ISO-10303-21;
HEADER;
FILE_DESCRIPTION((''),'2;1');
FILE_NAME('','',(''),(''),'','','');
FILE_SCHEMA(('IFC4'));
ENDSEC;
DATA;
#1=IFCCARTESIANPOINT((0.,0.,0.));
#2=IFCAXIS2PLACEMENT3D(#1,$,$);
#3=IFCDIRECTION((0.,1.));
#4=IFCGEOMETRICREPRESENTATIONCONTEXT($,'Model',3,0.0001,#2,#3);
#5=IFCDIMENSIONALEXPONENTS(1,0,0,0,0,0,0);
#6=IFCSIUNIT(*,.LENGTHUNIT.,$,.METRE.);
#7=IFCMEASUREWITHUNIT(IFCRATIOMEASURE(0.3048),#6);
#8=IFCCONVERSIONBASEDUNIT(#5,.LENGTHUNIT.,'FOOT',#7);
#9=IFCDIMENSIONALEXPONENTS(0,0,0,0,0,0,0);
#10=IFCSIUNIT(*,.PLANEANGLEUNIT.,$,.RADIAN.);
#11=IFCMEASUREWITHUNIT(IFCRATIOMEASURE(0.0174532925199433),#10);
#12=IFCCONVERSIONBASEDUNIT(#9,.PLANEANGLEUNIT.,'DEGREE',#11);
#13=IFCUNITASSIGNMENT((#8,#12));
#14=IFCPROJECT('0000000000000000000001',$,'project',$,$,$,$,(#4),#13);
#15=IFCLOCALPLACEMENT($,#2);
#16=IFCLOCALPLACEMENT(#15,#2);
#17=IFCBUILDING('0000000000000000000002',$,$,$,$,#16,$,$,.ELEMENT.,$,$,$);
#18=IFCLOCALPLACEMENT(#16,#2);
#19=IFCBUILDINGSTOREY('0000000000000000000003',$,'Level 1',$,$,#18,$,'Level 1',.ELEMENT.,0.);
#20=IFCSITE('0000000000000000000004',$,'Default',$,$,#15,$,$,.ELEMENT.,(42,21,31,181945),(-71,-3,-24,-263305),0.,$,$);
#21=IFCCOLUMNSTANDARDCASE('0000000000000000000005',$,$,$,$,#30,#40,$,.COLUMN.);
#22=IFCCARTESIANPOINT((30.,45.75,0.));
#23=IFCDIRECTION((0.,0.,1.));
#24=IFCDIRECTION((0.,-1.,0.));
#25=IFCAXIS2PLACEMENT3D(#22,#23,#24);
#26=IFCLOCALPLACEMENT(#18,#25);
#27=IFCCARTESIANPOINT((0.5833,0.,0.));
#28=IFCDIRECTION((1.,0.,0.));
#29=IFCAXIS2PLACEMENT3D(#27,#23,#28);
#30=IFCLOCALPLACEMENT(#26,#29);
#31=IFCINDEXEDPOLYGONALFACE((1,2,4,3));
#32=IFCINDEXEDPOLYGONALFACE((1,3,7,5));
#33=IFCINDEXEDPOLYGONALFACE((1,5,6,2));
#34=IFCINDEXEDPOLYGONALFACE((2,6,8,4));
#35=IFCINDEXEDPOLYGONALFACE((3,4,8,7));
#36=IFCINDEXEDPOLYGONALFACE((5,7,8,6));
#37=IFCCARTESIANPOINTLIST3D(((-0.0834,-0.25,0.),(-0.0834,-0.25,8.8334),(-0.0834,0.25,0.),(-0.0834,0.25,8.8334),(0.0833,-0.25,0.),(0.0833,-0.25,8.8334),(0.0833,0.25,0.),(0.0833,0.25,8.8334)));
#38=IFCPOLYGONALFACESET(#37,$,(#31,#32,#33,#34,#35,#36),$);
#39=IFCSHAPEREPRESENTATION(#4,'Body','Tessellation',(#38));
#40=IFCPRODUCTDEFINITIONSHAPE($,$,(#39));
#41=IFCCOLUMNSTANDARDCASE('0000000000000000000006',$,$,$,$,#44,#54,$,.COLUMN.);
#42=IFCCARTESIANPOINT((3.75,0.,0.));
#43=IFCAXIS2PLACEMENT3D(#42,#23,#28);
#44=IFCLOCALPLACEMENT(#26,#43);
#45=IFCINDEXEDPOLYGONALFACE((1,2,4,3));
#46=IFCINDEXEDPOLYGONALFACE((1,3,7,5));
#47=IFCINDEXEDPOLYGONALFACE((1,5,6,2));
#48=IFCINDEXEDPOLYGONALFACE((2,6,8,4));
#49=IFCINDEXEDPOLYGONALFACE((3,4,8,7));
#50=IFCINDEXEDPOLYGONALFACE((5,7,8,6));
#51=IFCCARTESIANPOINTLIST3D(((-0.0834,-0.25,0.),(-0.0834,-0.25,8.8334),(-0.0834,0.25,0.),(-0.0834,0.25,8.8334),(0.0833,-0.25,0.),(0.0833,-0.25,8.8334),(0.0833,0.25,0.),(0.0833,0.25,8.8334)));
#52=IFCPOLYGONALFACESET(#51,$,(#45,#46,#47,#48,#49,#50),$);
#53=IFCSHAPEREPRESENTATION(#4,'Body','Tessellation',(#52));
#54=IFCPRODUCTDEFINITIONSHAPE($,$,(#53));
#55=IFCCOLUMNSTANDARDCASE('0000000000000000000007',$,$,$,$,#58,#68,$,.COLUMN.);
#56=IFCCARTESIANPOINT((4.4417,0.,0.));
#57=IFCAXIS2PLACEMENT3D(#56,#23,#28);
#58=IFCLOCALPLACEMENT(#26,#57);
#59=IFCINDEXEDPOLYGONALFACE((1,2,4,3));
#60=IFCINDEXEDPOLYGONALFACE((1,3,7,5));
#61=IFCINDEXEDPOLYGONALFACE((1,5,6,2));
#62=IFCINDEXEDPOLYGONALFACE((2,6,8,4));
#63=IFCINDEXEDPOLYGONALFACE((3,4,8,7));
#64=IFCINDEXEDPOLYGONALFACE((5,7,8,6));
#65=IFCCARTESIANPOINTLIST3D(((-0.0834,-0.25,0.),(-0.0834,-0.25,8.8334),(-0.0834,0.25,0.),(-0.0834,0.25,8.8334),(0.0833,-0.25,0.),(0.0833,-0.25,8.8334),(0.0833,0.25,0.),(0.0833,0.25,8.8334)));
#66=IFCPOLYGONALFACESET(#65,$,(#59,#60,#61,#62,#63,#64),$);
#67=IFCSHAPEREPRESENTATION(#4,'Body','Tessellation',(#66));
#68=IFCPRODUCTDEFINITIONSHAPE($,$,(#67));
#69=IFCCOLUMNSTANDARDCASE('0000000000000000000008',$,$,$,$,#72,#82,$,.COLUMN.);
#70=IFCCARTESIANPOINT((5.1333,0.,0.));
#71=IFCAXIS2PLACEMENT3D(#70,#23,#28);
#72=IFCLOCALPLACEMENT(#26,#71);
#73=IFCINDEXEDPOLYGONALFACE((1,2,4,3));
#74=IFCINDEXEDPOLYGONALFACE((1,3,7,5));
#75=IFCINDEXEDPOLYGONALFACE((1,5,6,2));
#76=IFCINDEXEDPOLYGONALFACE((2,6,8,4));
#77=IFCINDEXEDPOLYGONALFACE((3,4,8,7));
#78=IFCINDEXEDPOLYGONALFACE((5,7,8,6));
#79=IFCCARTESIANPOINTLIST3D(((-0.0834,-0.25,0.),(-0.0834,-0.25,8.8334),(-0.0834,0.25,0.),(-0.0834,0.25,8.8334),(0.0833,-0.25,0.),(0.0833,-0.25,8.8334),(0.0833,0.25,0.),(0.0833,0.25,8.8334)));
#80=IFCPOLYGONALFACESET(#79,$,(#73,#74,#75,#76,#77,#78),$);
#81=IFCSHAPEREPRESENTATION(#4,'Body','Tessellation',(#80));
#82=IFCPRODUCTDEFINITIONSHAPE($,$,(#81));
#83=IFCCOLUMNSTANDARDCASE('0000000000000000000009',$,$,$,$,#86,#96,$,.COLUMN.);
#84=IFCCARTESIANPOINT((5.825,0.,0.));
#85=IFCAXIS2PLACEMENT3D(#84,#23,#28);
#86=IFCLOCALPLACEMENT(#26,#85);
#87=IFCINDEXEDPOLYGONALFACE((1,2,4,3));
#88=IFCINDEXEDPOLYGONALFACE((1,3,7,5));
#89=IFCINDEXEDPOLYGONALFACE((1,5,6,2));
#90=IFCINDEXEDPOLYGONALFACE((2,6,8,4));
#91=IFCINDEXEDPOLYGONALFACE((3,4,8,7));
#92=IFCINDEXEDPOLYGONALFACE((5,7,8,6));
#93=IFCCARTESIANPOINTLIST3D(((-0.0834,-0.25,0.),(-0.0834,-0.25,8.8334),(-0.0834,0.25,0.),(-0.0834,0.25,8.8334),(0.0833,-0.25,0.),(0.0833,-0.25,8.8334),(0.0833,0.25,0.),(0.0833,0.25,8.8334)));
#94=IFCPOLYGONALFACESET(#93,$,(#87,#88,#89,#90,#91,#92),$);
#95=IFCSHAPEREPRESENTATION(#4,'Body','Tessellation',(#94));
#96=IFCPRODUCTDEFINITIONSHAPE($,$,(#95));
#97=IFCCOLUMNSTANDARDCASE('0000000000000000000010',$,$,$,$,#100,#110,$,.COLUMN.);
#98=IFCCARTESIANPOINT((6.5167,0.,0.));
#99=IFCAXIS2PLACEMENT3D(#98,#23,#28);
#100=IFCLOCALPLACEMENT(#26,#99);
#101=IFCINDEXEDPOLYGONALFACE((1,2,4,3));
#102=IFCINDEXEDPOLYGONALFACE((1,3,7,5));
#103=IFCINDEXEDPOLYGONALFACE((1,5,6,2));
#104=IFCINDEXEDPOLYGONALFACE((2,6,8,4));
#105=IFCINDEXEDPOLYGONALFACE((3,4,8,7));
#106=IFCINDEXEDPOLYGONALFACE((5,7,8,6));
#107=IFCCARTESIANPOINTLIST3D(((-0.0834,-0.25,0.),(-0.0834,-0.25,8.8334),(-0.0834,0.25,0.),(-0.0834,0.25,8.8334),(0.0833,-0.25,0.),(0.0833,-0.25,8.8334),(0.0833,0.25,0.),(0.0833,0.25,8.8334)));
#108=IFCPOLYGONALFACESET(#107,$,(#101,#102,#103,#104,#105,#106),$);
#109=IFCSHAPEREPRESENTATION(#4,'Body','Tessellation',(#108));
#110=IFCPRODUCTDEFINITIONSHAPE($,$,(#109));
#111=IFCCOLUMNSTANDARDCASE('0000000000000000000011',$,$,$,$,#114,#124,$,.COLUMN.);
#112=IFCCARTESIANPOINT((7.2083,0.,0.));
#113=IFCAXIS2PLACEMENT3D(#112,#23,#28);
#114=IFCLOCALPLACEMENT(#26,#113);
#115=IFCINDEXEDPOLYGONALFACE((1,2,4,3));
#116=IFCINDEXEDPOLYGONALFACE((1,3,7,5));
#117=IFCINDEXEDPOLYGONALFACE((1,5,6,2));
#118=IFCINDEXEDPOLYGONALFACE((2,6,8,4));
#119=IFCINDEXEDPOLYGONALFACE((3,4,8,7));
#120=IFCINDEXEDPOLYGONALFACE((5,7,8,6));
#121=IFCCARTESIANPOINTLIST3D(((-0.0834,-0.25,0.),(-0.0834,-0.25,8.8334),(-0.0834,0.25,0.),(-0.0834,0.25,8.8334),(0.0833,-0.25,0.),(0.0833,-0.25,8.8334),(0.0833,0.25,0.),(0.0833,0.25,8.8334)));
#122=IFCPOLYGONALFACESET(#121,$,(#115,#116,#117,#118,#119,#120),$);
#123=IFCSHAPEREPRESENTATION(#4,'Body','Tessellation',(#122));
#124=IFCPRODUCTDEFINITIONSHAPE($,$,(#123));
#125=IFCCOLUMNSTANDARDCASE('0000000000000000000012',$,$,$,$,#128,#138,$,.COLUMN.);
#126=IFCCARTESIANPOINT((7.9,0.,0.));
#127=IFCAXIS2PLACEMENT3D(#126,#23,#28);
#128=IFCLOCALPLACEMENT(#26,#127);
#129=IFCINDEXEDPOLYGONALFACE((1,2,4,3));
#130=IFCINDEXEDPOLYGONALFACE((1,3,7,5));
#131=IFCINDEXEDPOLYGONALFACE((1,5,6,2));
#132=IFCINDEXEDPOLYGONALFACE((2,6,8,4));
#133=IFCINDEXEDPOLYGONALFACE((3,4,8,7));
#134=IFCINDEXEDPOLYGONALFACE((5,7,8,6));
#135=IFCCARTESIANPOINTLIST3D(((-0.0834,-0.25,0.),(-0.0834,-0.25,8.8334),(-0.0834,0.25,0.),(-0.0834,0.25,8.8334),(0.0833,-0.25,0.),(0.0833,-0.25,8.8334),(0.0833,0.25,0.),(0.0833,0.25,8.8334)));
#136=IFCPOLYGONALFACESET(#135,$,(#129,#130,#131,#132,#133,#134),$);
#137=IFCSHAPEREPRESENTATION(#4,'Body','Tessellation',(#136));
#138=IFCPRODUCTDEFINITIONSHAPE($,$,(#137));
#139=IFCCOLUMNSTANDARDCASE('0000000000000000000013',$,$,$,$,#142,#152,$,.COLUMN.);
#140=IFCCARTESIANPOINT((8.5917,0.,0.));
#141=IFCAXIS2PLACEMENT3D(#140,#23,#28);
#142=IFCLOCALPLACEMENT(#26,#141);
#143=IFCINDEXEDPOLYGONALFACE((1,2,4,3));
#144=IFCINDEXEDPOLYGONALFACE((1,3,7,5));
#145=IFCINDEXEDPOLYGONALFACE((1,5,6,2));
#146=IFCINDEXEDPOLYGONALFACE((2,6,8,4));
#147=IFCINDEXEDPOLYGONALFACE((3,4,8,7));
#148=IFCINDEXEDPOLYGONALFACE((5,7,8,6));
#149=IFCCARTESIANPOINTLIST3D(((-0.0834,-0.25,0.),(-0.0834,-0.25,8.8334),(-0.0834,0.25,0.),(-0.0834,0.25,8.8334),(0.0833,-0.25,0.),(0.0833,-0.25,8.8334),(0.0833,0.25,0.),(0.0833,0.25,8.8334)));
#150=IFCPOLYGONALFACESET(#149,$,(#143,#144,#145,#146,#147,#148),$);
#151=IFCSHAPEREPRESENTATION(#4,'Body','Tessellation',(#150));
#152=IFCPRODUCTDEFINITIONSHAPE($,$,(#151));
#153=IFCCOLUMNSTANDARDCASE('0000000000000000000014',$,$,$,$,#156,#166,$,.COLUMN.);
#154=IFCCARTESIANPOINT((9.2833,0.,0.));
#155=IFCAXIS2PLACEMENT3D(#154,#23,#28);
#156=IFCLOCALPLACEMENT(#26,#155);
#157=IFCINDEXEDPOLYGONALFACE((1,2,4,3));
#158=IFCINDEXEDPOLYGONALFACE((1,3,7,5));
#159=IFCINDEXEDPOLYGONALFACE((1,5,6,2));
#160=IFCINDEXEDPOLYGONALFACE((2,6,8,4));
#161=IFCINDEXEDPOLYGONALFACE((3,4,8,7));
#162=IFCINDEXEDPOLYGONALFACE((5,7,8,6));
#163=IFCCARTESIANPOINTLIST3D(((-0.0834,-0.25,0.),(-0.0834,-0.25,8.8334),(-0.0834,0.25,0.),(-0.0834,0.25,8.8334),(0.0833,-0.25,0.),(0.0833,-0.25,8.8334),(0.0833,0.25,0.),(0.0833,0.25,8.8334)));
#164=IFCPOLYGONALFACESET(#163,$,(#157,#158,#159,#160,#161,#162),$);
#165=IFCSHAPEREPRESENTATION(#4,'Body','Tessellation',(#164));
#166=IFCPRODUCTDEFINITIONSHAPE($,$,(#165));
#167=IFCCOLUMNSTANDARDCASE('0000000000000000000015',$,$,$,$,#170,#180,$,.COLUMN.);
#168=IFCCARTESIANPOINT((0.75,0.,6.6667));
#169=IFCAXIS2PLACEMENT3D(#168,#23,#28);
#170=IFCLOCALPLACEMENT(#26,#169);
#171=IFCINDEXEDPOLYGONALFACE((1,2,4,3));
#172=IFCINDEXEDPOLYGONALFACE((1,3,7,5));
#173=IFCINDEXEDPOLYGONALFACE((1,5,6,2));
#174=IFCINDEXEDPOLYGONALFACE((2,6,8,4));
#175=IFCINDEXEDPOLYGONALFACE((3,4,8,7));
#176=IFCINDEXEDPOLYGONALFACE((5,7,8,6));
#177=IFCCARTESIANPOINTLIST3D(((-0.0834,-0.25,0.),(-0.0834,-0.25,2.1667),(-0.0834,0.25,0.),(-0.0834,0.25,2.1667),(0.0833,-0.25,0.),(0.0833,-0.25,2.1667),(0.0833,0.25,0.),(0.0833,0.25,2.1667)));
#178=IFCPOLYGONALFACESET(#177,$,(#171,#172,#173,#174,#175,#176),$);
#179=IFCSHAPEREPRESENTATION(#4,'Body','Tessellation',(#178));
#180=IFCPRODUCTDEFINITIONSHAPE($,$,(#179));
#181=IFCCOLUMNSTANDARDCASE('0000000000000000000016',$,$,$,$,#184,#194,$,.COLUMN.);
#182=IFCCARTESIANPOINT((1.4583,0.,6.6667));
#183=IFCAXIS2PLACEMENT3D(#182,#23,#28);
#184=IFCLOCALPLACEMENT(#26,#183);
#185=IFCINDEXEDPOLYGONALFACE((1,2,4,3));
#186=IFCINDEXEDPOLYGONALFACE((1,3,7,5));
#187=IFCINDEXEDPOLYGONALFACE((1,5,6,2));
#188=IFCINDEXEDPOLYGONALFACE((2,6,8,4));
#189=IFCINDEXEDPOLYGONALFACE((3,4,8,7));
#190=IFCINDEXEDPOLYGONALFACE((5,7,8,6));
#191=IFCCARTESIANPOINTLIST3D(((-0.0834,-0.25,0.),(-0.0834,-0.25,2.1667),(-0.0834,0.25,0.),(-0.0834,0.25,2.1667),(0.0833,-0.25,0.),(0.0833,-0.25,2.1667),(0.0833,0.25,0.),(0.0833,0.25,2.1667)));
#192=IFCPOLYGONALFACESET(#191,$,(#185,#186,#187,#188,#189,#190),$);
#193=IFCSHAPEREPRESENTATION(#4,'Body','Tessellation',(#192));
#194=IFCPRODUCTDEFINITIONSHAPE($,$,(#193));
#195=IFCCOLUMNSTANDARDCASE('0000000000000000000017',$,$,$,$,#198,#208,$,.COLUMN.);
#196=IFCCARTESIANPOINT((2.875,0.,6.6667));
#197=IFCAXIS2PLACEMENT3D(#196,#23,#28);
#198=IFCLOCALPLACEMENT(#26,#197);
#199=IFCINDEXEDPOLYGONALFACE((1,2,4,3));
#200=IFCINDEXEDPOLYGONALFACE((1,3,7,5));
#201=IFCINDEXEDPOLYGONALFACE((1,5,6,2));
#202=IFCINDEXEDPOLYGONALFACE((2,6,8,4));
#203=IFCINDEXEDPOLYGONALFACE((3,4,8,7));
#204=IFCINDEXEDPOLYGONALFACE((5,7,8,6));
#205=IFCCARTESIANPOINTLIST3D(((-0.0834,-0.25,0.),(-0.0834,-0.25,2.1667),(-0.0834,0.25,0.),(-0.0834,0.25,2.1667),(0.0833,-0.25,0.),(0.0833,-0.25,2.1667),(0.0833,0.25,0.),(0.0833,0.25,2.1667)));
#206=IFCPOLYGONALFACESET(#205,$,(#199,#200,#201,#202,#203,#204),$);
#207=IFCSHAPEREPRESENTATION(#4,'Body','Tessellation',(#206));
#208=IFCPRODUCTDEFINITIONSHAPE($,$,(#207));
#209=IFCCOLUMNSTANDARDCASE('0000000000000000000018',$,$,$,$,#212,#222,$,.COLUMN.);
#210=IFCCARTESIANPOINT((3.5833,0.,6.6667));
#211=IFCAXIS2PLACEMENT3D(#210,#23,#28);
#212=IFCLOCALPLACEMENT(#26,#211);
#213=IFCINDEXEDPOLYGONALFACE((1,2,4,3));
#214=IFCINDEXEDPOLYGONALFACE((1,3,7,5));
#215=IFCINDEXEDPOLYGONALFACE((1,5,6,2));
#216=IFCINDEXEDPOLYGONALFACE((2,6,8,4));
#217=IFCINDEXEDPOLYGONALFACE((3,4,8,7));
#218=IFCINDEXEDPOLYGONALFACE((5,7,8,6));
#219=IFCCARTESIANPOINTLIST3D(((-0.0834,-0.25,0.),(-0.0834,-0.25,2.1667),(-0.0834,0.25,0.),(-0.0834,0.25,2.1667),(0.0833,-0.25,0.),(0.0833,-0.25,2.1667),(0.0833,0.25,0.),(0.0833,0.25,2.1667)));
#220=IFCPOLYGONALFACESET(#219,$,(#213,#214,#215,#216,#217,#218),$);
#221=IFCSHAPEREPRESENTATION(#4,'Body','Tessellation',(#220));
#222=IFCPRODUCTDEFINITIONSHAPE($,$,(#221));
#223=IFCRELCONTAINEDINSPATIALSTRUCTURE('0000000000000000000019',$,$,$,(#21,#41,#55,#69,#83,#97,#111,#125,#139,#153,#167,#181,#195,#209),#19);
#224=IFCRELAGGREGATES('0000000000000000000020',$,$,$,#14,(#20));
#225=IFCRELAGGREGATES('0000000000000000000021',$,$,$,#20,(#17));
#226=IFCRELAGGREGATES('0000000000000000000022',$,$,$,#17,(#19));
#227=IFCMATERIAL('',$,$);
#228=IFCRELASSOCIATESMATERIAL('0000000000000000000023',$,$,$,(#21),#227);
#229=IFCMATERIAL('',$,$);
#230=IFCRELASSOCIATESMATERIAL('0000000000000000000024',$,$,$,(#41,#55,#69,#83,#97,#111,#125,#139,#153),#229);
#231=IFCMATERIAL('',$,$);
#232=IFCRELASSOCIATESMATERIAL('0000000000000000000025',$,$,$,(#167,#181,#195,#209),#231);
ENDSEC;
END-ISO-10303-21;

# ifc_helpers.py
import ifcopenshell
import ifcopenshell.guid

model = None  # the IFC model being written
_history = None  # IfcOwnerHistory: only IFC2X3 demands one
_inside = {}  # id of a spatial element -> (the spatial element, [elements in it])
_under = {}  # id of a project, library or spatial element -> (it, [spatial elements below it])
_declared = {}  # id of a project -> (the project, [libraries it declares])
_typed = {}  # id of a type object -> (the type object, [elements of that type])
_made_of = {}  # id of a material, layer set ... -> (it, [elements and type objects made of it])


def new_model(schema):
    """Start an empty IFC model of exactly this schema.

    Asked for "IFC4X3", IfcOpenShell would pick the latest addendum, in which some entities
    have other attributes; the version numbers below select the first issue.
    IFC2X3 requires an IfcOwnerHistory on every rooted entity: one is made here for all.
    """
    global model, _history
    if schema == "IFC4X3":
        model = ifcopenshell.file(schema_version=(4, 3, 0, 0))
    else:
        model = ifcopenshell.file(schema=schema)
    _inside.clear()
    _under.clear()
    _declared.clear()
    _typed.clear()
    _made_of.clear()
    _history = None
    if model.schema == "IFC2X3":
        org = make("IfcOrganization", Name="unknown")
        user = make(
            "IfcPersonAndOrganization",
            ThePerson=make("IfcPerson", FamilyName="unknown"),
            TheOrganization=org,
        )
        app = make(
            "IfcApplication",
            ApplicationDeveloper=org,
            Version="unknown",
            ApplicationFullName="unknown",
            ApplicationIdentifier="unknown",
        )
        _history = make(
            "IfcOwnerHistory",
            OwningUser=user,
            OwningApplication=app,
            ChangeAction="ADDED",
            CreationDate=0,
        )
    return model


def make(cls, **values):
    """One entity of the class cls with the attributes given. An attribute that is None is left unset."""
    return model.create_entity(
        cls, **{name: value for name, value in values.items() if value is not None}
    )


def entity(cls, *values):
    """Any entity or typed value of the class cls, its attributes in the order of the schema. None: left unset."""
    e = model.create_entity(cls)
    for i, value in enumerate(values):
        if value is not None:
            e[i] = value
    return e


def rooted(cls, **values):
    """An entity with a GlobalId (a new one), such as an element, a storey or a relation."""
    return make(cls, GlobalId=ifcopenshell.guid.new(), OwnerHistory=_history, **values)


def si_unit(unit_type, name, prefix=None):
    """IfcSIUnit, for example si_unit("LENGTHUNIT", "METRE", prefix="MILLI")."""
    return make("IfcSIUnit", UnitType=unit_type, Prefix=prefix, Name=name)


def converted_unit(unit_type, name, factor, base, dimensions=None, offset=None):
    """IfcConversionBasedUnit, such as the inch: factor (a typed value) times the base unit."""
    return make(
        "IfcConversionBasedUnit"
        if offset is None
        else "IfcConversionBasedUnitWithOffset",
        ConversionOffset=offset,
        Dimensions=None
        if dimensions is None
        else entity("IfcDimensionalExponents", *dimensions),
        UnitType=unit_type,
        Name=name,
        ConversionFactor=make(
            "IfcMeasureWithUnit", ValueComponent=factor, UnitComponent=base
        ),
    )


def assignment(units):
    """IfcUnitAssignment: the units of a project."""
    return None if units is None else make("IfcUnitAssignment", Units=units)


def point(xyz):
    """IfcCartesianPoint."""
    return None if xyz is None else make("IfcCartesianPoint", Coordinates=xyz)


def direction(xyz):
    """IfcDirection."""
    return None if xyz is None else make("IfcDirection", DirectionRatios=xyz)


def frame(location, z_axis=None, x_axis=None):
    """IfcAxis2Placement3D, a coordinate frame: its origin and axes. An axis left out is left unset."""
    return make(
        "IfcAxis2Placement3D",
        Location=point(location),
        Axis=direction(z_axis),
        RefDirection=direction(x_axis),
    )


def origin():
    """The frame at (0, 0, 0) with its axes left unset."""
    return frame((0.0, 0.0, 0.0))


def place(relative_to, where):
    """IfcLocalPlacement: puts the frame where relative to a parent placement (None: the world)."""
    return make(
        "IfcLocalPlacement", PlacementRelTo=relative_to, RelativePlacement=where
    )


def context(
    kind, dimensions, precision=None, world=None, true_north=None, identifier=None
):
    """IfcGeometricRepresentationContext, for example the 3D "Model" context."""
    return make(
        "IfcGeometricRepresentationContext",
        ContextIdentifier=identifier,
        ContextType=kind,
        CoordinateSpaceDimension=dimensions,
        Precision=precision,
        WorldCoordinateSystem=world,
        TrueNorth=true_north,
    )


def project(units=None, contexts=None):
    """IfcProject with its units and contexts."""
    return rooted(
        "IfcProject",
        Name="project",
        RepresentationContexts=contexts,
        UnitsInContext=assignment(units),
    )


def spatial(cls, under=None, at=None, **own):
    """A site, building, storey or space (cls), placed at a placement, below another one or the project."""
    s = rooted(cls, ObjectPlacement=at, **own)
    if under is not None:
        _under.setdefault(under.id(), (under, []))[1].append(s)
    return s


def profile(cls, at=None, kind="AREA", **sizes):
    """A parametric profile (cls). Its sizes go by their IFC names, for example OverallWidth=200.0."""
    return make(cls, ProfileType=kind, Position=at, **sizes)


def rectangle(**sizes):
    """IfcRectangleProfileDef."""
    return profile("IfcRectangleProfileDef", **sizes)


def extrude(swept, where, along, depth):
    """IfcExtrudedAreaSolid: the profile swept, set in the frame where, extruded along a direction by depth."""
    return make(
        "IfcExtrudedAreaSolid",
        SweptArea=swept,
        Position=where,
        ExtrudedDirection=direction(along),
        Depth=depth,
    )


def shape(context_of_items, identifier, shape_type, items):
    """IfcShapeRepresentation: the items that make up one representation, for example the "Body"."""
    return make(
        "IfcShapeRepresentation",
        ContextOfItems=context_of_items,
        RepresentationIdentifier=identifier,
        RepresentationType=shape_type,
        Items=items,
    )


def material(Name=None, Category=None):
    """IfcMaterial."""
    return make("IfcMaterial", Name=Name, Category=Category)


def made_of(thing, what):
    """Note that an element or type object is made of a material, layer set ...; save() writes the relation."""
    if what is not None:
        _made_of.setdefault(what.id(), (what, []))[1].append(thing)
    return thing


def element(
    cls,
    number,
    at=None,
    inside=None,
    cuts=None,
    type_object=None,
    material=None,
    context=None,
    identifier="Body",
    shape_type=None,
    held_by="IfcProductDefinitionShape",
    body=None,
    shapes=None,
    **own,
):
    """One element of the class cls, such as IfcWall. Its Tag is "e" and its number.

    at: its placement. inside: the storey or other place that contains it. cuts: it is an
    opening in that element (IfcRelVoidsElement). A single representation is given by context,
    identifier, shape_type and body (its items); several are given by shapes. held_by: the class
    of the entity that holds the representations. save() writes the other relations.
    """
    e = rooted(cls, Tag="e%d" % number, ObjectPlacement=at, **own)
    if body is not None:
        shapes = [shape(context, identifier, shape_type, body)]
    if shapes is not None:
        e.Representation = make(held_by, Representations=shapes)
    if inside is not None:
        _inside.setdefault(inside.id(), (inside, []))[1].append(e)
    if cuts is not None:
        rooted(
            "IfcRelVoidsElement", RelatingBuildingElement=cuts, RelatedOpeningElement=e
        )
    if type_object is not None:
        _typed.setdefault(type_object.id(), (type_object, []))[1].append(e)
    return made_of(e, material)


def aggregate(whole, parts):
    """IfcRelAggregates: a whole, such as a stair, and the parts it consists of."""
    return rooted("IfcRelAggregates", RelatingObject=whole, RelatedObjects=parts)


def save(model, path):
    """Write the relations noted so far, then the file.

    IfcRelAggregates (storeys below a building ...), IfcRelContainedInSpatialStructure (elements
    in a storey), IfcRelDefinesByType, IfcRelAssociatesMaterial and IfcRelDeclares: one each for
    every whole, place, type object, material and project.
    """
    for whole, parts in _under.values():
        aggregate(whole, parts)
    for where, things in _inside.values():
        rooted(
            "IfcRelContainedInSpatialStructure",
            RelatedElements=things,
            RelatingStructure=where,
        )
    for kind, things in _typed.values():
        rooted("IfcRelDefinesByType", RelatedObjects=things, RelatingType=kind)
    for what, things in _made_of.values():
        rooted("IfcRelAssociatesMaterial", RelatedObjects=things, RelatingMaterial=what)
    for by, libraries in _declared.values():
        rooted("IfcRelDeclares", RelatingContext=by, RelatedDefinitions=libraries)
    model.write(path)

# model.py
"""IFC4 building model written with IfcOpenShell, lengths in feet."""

from ifc_helpers import new_model, entity, si_unit, converted_unit, direction, frame, origin, place, context, project, spatial, rectangle, extrude, material, element, save


model = new_model("IFC4")

# Units and contexts
model_context = context("Model", 3, precision=0.0001, world=origin(), true_north=direction((0.0, 1.0)))
ifc_project = project(units=[converted_unit("LENGTHUNIT", "FOOT", entity("IfcRatioMeasure", 0.3048), si_unit("LENGTHUNIT", "METRE"), dimensions=[1, 0, 0, 0, 0, 0, 0]), converted_unit("PLANEANGLEUNIT", "DEGREE", entity("IfcRatioMeasure", 0.0174532925199433), si_unit("PLANEANGLEUNIT", "RADIAN"), dimensions=[0, 0, 0, 0, 0, 0, 0])], contexts=[model_context])

# Site, building, storey
site_placement = place(None, origin())
site = spatial("IfcSite", under=ifc_project, at=site_placement, Name="Default", CompositionType="ELEMENT", RefLatitude=(42, 21, 31, 181945), RefLongitude=(-71, -3, -24, -263305), RefElevation=0.0)
building_placement = place(site_placement, origin())
building = spatial("IfcBuilding", under=site, at=building_placement, CompositionType="ELEMENT")
storey_placement = place(building_placement, origin())
storey = spatial("IfcBuildingStorey", under=building, at=storey_placement, Name="Level 1", LongName="Level 1", CompositionType="ELEMENT", Elevation=0.0)

# Columns
ifc_material_1 = material(Name="")
ifc_material_2 = material(Name="")
placement_1 = place(storey_placement, frame((30.0, 45.75, 0.0), z_axis=(0.0, 0.0, 1.0), x_axis=(0.0, -1.0, 0.0)))
for number, where, z_axis, x_axis in (
    (1, (0.5833, 0.0, 0.0), (0.0, 0.0, 1.0), (1.0, 0.0, 0.0)),
):
    element("IfcColumnStandardCase", number, at=place(placement_1, frame(where, z_axis=z_axis, x_axis=x_axis)), inside=storey, material=ifc_material_2, PredefinedType="COLUMN", context=model_context, shape_type="SweptSolid", body=[
        extrude(rectangle(XDim=0.1667, YDim=0.5), origin(), (0.0, 0.0, 1.0), 8.8334),
    ])
for number, where, z_axis, x_axis in (
    (2, (3.75, 0.0, 0.0), (0.0, 0.0, 1.0), (1.0, 0.0, 0.0)),
    (3, (4.4417, 0.0, 0.0), (0.0, 0.0, 1.0), (1.0, 0.0, 0.0)),
    (4, (5.1333, 0.0, 0.0), (0.0, 0.0, 1.0), (1.0, 0.0, 0.0)),
    (5, (5.825, 0.0, 0.0), (0.0, 0.0, 1.0), (1.0, 0.0, 0.0)),
    (6, (6.5167, 0.0, 0.0), (0.0, 0.0, 1.0), (1.0, 0.0, 0.0)),
    (7, (7.2083, 0.0, 0.0), (0.0, 0.0, 1.0), (1.0, 0.0, 0.0)),
    (8, (7.9, 0.0, 0.0), (0.0, 0.0, 1.0), (1.0, 0.0, 0.0)),
    (9, (8.5917, 0.0, 0.0), (0.0, 0.0, 1.0), (1.0, 0.0, 0.0)),
    (10, (9.2833, 0.0, 0.0), (0.0, 0.0, 1.0), (1.0, 0.0, 0.0)),
):
    element("IfcColumnStandardCase", number, at=place(placement_1, frame(where, z_axis=z_axis, x_axis=x_axis)), inside=storey, material=ifc_material_1, PredefinedType="COLUMN", context=model_context, shape_type="SweptSolid", body=[
        extrude(rectangle(XDim=0.1667, YDim=0.5), origin(), (0.0, 0.0, 1.0), 8.8334),
    ])
ifc_material_3 = material(Name="")
for number, where, z_axis, x_axis in (
    (11, (0.75, 0.0, 6.6667), (0.0, 0.0, 1.0), (1.0, 0.0, 0.0)),
    (12, (1.4583, 0.0, 6.6667), (0.0, 0.0, 1.0), (1.0, 0.0, 0.0)),
    (13, (2.875, 0.0, 6.6667), (0.0, 0.0, 1.0), (1.0, 0.0, 0.0)),
    (14, (3.5833, 0.0, 6.6667), (0.0, 0.0, 1.0), (1.0, 0.0, 0.0)),
):
    element("IfcColumnStandardCase", number, at=place(placement_1, frame(where, z_axis=z_axis, x_axis=x_axis)), inside=storey, material=ifc_material_3, PredefinedType="COLUMN", context=model_context, shape_type="SweptSolid", body=[
        extrude(rectangle(XDim=0.1667, YDim=0.5), origin(), (0.0, 0.0, 1.0), 2.1667),
    ])

save(model, "model.ifc")
